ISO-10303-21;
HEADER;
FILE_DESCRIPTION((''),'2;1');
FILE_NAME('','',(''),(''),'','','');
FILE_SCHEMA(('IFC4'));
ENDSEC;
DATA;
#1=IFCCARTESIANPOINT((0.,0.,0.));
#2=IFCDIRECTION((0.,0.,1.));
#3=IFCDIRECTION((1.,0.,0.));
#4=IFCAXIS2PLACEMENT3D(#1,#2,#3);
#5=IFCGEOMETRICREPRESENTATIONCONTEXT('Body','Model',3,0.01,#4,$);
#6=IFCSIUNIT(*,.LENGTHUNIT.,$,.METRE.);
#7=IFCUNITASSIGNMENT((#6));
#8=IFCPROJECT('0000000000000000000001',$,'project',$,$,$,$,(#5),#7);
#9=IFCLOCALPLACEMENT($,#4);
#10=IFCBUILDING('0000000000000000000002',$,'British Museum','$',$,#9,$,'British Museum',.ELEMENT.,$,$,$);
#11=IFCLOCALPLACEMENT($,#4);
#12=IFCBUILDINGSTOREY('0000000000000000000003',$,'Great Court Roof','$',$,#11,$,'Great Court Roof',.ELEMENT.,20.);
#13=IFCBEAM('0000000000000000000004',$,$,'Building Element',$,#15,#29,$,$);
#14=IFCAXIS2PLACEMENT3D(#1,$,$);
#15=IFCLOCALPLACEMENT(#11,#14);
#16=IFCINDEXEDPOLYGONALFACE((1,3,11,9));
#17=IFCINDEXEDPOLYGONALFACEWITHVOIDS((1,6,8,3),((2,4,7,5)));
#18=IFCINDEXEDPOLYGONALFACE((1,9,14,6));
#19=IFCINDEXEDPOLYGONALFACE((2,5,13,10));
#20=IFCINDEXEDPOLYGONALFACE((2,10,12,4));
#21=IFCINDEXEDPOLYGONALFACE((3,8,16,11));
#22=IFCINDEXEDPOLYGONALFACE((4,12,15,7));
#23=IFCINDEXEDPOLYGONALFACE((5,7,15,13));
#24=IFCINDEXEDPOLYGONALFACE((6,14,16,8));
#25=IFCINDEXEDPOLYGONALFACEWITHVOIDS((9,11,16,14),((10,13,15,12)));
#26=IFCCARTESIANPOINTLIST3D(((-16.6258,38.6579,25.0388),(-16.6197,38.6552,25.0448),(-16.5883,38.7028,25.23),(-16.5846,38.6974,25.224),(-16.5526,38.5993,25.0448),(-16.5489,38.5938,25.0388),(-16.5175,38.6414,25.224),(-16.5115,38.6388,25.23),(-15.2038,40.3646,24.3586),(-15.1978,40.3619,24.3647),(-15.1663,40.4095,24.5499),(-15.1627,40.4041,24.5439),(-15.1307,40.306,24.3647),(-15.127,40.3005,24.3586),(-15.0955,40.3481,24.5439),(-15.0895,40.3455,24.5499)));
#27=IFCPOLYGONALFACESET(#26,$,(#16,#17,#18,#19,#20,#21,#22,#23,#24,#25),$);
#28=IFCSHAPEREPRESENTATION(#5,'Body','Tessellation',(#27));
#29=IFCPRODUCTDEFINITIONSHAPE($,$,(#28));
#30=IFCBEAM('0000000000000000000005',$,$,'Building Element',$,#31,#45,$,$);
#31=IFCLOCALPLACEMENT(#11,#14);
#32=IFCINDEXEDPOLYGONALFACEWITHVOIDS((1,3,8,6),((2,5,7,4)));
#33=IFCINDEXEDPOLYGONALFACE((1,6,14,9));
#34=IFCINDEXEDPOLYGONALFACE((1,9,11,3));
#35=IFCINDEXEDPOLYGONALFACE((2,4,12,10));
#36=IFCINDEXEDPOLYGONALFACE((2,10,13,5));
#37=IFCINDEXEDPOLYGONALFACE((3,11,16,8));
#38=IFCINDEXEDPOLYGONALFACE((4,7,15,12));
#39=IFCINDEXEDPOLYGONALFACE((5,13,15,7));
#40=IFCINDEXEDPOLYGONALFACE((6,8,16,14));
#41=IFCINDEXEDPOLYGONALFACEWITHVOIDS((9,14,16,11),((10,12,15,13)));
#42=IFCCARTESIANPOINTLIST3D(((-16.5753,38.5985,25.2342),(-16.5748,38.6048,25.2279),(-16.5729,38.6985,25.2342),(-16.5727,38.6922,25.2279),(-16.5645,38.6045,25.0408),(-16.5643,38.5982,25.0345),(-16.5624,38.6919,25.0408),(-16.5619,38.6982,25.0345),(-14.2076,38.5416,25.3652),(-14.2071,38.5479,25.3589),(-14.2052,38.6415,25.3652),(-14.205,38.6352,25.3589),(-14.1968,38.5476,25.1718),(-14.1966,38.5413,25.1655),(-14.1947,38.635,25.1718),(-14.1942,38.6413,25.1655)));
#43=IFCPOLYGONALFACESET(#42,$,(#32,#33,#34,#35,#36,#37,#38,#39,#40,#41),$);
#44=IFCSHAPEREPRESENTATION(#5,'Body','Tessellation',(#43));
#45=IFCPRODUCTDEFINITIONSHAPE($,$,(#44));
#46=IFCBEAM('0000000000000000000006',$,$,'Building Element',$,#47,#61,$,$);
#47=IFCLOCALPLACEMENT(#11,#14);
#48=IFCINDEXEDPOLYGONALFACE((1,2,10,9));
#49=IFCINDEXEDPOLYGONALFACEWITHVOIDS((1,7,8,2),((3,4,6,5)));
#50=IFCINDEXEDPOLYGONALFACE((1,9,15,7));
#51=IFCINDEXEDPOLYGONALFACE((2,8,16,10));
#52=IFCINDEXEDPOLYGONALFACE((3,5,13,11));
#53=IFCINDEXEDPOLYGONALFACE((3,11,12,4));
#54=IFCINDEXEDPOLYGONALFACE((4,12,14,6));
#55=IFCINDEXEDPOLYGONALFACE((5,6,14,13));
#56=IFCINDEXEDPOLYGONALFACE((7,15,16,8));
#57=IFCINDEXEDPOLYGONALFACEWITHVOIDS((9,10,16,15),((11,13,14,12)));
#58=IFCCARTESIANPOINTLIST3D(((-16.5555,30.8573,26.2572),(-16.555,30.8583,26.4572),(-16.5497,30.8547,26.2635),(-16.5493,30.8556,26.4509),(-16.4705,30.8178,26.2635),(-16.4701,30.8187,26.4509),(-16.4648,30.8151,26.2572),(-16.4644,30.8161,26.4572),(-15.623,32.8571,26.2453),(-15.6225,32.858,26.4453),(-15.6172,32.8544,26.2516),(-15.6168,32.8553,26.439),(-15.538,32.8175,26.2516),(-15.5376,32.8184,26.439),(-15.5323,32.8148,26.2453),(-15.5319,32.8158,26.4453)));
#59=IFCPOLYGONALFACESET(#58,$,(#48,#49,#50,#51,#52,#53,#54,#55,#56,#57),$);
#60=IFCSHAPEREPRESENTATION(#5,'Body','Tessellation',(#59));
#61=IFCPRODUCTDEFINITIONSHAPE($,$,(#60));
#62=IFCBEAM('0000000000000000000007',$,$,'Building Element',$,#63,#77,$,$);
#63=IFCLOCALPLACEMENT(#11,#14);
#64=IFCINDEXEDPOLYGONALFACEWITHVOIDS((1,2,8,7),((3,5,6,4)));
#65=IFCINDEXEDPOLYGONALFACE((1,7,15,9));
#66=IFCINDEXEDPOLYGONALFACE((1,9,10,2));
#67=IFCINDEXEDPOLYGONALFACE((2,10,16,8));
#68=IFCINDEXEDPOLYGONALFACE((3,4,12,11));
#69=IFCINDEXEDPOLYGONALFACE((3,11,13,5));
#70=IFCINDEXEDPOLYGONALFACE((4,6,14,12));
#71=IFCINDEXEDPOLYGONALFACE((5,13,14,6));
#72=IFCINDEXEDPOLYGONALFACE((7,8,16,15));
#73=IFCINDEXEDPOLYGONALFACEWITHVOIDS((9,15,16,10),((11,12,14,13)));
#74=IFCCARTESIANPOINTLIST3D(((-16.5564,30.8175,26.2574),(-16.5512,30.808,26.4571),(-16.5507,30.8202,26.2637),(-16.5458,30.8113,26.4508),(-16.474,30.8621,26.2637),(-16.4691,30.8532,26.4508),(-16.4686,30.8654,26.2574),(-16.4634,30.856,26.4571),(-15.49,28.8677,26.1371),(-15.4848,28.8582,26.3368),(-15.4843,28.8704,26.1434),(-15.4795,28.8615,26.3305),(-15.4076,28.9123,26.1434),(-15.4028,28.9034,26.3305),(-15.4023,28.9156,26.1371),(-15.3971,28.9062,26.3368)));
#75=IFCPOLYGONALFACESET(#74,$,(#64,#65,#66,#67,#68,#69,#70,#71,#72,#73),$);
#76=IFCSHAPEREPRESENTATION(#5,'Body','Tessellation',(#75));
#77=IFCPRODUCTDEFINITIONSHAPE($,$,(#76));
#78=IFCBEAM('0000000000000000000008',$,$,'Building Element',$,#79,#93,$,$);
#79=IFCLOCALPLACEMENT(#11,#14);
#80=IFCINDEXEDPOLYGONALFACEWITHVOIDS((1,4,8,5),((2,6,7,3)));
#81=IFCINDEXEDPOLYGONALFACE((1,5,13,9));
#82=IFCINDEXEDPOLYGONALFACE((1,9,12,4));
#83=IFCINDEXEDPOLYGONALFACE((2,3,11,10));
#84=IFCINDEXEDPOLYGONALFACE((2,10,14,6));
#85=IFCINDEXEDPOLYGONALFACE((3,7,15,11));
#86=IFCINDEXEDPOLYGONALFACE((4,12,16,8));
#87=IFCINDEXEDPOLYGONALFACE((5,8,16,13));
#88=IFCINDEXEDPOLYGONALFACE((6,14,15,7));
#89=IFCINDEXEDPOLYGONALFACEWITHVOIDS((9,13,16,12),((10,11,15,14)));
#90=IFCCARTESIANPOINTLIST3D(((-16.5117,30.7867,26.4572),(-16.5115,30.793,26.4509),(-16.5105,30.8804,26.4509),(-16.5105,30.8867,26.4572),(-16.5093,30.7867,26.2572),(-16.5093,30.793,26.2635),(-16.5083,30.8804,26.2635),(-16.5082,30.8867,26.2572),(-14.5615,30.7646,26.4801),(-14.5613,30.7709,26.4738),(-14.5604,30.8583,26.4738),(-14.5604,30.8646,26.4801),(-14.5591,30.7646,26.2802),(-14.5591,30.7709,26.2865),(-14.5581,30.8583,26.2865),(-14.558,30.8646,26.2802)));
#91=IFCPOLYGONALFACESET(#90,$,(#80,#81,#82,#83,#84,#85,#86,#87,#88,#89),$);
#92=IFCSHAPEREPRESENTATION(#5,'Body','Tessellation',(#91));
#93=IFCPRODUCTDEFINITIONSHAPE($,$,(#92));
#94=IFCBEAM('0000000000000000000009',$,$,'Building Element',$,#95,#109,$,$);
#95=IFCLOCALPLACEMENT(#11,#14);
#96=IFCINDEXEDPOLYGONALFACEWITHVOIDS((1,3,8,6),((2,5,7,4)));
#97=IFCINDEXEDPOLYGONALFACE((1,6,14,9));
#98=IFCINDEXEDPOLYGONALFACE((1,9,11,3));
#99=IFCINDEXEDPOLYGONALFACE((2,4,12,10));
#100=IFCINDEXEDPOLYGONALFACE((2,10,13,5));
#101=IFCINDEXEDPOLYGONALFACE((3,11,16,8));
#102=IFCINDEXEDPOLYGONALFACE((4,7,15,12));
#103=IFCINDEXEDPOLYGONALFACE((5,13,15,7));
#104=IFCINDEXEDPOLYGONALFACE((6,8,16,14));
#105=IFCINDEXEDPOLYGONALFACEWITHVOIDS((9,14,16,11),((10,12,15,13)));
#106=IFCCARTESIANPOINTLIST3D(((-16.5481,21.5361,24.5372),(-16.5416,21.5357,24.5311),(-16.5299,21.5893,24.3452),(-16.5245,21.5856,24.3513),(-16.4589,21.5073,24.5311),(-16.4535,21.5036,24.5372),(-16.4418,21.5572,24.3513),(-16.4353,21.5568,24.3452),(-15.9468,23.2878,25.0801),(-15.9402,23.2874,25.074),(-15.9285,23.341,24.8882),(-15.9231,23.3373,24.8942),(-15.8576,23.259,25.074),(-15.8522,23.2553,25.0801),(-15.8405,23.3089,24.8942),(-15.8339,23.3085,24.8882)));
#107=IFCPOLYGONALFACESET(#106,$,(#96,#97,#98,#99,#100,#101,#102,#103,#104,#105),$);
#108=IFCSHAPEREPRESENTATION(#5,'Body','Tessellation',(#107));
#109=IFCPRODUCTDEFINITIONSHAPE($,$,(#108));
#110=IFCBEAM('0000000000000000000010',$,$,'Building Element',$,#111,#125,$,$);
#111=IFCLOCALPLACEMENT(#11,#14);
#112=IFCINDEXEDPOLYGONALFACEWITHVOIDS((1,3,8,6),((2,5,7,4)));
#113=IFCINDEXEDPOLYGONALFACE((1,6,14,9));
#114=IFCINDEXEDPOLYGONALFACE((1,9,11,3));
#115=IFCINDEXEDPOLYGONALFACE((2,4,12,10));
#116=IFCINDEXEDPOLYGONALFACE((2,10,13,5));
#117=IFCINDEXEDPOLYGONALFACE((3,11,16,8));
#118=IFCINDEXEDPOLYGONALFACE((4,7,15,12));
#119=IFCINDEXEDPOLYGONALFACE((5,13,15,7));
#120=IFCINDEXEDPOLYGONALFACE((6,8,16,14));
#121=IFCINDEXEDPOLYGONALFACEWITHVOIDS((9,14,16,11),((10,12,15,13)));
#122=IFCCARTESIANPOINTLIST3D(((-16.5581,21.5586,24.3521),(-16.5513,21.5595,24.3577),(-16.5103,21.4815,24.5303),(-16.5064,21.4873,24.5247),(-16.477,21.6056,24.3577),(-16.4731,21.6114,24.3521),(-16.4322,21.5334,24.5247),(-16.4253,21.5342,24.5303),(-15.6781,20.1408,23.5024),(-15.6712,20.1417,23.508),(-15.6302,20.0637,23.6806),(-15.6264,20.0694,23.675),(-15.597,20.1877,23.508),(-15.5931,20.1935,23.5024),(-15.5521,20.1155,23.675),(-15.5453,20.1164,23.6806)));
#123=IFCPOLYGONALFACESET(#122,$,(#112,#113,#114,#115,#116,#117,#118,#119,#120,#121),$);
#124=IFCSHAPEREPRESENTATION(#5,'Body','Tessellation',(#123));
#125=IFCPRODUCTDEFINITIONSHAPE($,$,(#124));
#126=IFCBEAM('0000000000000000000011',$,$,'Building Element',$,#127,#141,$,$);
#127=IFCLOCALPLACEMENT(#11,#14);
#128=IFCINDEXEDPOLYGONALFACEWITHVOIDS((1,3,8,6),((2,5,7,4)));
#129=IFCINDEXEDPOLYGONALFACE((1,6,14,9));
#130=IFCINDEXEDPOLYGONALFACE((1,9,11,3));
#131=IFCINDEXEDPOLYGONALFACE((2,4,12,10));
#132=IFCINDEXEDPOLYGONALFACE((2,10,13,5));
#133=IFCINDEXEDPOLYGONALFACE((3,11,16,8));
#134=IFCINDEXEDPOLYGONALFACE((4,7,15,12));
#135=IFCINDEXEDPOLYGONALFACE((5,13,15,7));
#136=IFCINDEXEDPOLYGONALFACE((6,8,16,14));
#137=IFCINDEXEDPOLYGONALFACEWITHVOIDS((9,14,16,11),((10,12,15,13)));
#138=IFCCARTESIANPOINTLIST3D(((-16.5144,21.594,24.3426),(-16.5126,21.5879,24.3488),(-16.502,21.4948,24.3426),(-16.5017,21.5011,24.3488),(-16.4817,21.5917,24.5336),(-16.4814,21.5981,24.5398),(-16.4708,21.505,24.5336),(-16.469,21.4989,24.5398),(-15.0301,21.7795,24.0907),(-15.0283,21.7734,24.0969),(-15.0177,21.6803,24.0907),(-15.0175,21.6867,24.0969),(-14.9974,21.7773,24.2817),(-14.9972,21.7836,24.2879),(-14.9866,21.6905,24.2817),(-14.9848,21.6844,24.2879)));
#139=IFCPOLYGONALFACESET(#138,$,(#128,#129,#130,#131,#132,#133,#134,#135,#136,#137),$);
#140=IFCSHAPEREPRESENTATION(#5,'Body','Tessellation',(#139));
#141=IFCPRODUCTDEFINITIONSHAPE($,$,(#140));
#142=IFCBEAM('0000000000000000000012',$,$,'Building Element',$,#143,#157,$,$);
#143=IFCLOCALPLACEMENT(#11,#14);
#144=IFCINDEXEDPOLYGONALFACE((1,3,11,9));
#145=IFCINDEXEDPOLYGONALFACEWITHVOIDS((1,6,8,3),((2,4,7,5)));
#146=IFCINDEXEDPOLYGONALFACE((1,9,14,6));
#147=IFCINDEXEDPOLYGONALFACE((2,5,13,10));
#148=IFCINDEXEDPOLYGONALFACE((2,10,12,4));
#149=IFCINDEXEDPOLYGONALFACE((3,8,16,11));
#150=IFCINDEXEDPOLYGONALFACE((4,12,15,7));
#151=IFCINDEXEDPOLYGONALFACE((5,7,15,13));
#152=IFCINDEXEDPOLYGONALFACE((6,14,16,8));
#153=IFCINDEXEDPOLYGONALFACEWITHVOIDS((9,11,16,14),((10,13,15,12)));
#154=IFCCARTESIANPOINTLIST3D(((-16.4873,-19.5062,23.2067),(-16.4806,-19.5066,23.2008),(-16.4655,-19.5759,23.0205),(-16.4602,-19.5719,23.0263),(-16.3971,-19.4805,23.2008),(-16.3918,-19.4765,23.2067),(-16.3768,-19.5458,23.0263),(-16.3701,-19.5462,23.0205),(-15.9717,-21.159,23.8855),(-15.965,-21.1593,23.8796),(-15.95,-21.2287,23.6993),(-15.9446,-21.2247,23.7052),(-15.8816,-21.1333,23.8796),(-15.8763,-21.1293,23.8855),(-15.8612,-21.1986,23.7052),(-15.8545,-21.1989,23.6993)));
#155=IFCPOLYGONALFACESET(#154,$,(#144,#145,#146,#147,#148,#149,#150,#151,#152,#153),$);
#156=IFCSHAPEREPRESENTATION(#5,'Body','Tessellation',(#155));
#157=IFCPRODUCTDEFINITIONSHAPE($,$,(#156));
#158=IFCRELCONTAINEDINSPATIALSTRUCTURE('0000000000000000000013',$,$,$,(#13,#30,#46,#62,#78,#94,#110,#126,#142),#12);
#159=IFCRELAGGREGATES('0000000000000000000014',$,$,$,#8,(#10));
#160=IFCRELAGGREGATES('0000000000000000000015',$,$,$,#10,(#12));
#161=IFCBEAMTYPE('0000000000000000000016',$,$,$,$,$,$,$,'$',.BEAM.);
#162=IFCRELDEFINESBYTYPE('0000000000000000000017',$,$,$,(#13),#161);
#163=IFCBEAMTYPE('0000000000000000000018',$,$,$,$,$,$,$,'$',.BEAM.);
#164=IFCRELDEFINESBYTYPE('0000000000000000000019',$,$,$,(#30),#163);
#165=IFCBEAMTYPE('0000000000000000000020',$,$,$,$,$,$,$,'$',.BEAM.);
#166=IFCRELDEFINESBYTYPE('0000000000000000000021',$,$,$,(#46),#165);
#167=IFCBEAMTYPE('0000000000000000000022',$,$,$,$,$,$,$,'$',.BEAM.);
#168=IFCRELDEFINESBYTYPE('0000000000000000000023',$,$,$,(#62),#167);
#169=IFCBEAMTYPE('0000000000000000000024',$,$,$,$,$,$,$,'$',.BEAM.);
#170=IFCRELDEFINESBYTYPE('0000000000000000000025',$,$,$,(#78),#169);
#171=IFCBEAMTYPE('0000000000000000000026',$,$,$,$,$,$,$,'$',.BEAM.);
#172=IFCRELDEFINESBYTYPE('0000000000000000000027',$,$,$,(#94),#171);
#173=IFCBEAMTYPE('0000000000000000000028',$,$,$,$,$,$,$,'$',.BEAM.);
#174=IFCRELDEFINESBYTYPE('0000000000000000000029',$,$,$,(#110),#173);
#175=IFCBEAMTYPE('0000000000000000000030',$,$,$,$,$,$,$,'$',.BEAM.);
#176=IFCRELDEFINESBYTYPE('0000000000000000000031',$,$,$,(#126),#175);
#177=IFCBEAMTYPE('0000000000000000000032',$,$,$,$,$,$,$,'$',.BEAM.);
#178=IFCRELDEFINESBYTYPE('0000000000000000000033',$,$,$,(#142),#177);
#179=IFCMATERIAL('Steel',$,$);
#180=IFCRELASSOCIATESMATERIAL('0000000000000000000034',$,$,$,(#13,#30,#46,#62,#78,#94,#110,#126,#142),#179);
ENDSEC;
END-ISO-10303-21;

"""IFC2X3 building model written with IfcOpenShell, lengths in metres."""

from ifc_helpers import new_model, si_unit, frame, origin_with_axes, origin_2d, place, context, project, spatial, hollow_rectangle, extrude, material, type_object, element, save


model = new_model("IFC2X3")

# Units and contexts
model_context = context("Model", 3, precision=0.01, world=origin_with_axes(), identifier="Body")
ifc_project = project(units=[si_unit("LENGTHUNIT", "METRE")], contexts=[model_context])

# Building, storey
building_placement = place(None, origin_with_axes())
building = spatial("IfcBuilding", under=ifc_project, at=building_placement, Name="British Museum", Description="$", LongName="British Museum", CompositionType="ELEMENT")
storey_placement = place(None, origin_with_axes())
storey = spatial("IfcBuildingStorey", under=building, at=storey_placement, Name="Great Court Roof", Description="$", LongName="Great Court Roof", CompositionType="ELEMENT", Elevation=20.0)

# Beams
ifc_material = material(Name="Steel")
beam_type_1 = type_object("IfcBeamType", ElementType="$", PredefinedType="BEAM")
beam_1_placement = place(None, origin_with_axes())
element("IfcBeam", 1, at=beam_1_placement, inside=storey, type_object=beam_type_1, material=ifc_material, Description="Building Element", context=model_context, shape_type="SweptSolid", body=[
    extrude(hollow_rectangle(XDim=0.1, YDim=0.2, WallThickness=0.0063, InnerFilletRadius=0.0, OuterFilletRadius=0.0, at=origin_2d()), frame((-16.5686, 38.6483, 25.1344), z_axis=(0.61206, 0.73463, -0.292748), x_axis=(-0.768289, 0.640104, 0.0)), (0.0, 0.0, 1.0), 2.3232),
])
beam_type_2 = type_object("IfcBeamType", ElementType="$", PredefinedType="BEAM")
beam_2_placement = place(None, origin_with_axes())
element("IfcBeam", 2, at=beam_2_placement, inside=storey, type_object=beam_type_2, material=ifc_material, Description="Building Element", context=model_context, shape_type="SweptSolid", body=[
    extrude(hollow_rectangle(XDim=0.1, YDim=0.2, WallThickness=0.0063, InnerFilletRadius=0.0, OuterFilletRadius=0.0, at=origin_2d()), frame((-16.5686, 38.6483, 25.1344), z_axis=(0.998186, -0.024001, 0.05522), x_axis=(0.024038, 0.999711, 0.0)), (0.0, 0.0, 1.0), 2.372),
])
beam_type_3 = type_object("IfcBeamType", ElementType="$", PredefinedType="BEAM")
beam_3_placement = place(None, origin_with_axes())
element("IfcBeam", 3, at=beam_3_placement, inside=storey, type_object=beam_type_3, material=ifc_material, Description="Building Element", context=model_context, shape_type="SweptSolid", body=[
    extrude(hollow_rectangle(XDim=0.1, YDim=0.2, WallThickness=0.0063, InnerFilletRadius=0.0, OuterFilletRadius=0.0, at=origin_2d()), frame((-16.5099, 30.8367, 26.3572), z_axis=(0.422613, 0.906294, -0.005413), x_axis=(-0.906308, 0.422619, 0.0)), (0.0, 0.0, 1.0), 2.2065),
])
beam_type_4 = type_object("IfcBeamType", ElementType="$", PredefinedType="BEAM")
beam_4_placement = place(None, origin_with_axes())
element("IfcBeam", 4, at=beam_4_placement, inside=storey, type_object=beam_type_4, material=ifc_material, Description="Building Element", context=model_context, shape_type="SweptSolid", body=[
    extrude(hollow_rectangle(XDim=0.1, YDim=0.2, WallThickness=0.0063, InnerFilletRadius=0.0, OuterFilletRadius=0.0, at=origin_2d()), frame((-16.5099, 30.8367, 26.3572), z_axis=(0.479136, -0.876075, -0.054049), x_axis=(0.877357, 0.479838, 0.0)), (0.0, 0.0, 1.0), 2.2256),
])
beam_type_5 = type_object("IfcBeamType", ElementType="$", PredefinedType="BEAM")
beam_5_placement = place(None, origin_with_axes())
element("IfcBeam", 5, at=beam_5_placement, inside=storey, type_object=beam_type_5, material=ifc_material, Description="Building Element", context=model_context, shape_type="SweptSolid", body=[
    extrude(hollow_rectangle(XDim=0.1, YDim=0.2, WallThickness=0.0063, InnerFilletRadius=0.0, OuterFilletRadius=0.0, at=origin_2d()), frame((-16.5099, 30.8367, 26.3572), z_axis=(0.999867, -0.011338, 0.011758), x_axis=(0.011339, 0.999936, 0.0)), (0.0, 0.0, 1.0), 1.9504),
])
beam_type_6 = type_object("IfcBeamType", ElementType="$", PredefinedType="BEAM")
beam_6_placement = place(None, origin_with_axes())
element("IfcBeam", 6, at=beam_6_placement, inside=storey, type_object=beam_type_6, material=ifc_material, Description="Building Element", context=model_context, shape_type="SweptSolid", body=[
    extrude(hollow_rectangle(XDim=0.1, YDim=0.2, WallThickness=0.0063, InnerFilletRadius=0.0, OuterFilletRadius=0.0, at=origin_2d()), frame((-16.4917, 21.5464, 24.4412), z_axis=(0.31158, 0.907624, 0.281313), x_axis=(-0.94582, 0.324692, 0.0)), (0.0, 0.0, 1.0), 1.93),
])
beam_type_7 = type_object("IfcBeamType", ElementType="$", PredefinedType="BEAM")
beam_7_placement = place(None, origin_with_axes())
element("IfcBeam", 7, at=beam_7_placement, inside=storey, type_object=beam_type_7, material=ifc_material, Description="Building Element", context=model_context, shape_type="SweptSolid", body=[
    extrude(hollow_rectangle(XDim=0.1, YDim=0.2, WallThickness=0.0063, InnerFilletRadius=0.0, OuterFilletRadius=0.0, at=origin_2d()), frame((-16.4917, 21.5464, 24.4412), z_axis=(0.469946, -0.757143, -0.453746), x_axis=(0.849643, 0.527359, 0.0)), (0.0, 0.0, 1.0), 1.8726),
])
beam_type_8 = type_object("IfcBeamType", ElementType="$", PredefinedType="BEAM")
beam_8_placement = place(None, origin_with_axes())
element("IfcBeam", 8, at=beam_8_placement, inside=storey, type_object=beam_type_8, material=ifc_material, Description="Building Element", context=model_context, shape_type="SweptSolid", body=[
    extrude(hollow_rectangle(XDim=0.1, YDim=0.2, WallThickness=0.0063, InnerFilletRadius=0.0, OuterFilletRadius=0.0, at=origin_2d()), frame((-16.4917, 21.5464, 24.4412), z_axis=(0.978504, 0.122318, -0.166038), x_axis=(-0.12404, 0.992277, 0.0)), (0.0, 0.0, 1.0), 1.5169),
])
beam_type_9 = type_object("IfcBeamType", ElementType="$", PredefinedType="BEAM")
beam_9_placement = place(None, origin_with_axes())
element("IfcBeam", 9, at=beam_9_placement, inside=storey, type_object=beam_type_9, material=ifc_material, Description="Building Element", context=model_context, shape_type="SweptSolid", body=[
    extrude(hollow_rectangle(XDim=0.1, YDim=0.2, WallThickness=0.0063, InnerFilletRadius=0.0, OuterFilletRadius=0.0, at=origin_2d()), frame((-16.4287, -19.5262, 23.1136), z_axis=(0.277226, -0.888759, 0.365039), x_axis=(0.954636, 0.297775, 0.0)), (0.0, 0.0, 1.0), 1.8597),
])

save(model, "model.ifc")
